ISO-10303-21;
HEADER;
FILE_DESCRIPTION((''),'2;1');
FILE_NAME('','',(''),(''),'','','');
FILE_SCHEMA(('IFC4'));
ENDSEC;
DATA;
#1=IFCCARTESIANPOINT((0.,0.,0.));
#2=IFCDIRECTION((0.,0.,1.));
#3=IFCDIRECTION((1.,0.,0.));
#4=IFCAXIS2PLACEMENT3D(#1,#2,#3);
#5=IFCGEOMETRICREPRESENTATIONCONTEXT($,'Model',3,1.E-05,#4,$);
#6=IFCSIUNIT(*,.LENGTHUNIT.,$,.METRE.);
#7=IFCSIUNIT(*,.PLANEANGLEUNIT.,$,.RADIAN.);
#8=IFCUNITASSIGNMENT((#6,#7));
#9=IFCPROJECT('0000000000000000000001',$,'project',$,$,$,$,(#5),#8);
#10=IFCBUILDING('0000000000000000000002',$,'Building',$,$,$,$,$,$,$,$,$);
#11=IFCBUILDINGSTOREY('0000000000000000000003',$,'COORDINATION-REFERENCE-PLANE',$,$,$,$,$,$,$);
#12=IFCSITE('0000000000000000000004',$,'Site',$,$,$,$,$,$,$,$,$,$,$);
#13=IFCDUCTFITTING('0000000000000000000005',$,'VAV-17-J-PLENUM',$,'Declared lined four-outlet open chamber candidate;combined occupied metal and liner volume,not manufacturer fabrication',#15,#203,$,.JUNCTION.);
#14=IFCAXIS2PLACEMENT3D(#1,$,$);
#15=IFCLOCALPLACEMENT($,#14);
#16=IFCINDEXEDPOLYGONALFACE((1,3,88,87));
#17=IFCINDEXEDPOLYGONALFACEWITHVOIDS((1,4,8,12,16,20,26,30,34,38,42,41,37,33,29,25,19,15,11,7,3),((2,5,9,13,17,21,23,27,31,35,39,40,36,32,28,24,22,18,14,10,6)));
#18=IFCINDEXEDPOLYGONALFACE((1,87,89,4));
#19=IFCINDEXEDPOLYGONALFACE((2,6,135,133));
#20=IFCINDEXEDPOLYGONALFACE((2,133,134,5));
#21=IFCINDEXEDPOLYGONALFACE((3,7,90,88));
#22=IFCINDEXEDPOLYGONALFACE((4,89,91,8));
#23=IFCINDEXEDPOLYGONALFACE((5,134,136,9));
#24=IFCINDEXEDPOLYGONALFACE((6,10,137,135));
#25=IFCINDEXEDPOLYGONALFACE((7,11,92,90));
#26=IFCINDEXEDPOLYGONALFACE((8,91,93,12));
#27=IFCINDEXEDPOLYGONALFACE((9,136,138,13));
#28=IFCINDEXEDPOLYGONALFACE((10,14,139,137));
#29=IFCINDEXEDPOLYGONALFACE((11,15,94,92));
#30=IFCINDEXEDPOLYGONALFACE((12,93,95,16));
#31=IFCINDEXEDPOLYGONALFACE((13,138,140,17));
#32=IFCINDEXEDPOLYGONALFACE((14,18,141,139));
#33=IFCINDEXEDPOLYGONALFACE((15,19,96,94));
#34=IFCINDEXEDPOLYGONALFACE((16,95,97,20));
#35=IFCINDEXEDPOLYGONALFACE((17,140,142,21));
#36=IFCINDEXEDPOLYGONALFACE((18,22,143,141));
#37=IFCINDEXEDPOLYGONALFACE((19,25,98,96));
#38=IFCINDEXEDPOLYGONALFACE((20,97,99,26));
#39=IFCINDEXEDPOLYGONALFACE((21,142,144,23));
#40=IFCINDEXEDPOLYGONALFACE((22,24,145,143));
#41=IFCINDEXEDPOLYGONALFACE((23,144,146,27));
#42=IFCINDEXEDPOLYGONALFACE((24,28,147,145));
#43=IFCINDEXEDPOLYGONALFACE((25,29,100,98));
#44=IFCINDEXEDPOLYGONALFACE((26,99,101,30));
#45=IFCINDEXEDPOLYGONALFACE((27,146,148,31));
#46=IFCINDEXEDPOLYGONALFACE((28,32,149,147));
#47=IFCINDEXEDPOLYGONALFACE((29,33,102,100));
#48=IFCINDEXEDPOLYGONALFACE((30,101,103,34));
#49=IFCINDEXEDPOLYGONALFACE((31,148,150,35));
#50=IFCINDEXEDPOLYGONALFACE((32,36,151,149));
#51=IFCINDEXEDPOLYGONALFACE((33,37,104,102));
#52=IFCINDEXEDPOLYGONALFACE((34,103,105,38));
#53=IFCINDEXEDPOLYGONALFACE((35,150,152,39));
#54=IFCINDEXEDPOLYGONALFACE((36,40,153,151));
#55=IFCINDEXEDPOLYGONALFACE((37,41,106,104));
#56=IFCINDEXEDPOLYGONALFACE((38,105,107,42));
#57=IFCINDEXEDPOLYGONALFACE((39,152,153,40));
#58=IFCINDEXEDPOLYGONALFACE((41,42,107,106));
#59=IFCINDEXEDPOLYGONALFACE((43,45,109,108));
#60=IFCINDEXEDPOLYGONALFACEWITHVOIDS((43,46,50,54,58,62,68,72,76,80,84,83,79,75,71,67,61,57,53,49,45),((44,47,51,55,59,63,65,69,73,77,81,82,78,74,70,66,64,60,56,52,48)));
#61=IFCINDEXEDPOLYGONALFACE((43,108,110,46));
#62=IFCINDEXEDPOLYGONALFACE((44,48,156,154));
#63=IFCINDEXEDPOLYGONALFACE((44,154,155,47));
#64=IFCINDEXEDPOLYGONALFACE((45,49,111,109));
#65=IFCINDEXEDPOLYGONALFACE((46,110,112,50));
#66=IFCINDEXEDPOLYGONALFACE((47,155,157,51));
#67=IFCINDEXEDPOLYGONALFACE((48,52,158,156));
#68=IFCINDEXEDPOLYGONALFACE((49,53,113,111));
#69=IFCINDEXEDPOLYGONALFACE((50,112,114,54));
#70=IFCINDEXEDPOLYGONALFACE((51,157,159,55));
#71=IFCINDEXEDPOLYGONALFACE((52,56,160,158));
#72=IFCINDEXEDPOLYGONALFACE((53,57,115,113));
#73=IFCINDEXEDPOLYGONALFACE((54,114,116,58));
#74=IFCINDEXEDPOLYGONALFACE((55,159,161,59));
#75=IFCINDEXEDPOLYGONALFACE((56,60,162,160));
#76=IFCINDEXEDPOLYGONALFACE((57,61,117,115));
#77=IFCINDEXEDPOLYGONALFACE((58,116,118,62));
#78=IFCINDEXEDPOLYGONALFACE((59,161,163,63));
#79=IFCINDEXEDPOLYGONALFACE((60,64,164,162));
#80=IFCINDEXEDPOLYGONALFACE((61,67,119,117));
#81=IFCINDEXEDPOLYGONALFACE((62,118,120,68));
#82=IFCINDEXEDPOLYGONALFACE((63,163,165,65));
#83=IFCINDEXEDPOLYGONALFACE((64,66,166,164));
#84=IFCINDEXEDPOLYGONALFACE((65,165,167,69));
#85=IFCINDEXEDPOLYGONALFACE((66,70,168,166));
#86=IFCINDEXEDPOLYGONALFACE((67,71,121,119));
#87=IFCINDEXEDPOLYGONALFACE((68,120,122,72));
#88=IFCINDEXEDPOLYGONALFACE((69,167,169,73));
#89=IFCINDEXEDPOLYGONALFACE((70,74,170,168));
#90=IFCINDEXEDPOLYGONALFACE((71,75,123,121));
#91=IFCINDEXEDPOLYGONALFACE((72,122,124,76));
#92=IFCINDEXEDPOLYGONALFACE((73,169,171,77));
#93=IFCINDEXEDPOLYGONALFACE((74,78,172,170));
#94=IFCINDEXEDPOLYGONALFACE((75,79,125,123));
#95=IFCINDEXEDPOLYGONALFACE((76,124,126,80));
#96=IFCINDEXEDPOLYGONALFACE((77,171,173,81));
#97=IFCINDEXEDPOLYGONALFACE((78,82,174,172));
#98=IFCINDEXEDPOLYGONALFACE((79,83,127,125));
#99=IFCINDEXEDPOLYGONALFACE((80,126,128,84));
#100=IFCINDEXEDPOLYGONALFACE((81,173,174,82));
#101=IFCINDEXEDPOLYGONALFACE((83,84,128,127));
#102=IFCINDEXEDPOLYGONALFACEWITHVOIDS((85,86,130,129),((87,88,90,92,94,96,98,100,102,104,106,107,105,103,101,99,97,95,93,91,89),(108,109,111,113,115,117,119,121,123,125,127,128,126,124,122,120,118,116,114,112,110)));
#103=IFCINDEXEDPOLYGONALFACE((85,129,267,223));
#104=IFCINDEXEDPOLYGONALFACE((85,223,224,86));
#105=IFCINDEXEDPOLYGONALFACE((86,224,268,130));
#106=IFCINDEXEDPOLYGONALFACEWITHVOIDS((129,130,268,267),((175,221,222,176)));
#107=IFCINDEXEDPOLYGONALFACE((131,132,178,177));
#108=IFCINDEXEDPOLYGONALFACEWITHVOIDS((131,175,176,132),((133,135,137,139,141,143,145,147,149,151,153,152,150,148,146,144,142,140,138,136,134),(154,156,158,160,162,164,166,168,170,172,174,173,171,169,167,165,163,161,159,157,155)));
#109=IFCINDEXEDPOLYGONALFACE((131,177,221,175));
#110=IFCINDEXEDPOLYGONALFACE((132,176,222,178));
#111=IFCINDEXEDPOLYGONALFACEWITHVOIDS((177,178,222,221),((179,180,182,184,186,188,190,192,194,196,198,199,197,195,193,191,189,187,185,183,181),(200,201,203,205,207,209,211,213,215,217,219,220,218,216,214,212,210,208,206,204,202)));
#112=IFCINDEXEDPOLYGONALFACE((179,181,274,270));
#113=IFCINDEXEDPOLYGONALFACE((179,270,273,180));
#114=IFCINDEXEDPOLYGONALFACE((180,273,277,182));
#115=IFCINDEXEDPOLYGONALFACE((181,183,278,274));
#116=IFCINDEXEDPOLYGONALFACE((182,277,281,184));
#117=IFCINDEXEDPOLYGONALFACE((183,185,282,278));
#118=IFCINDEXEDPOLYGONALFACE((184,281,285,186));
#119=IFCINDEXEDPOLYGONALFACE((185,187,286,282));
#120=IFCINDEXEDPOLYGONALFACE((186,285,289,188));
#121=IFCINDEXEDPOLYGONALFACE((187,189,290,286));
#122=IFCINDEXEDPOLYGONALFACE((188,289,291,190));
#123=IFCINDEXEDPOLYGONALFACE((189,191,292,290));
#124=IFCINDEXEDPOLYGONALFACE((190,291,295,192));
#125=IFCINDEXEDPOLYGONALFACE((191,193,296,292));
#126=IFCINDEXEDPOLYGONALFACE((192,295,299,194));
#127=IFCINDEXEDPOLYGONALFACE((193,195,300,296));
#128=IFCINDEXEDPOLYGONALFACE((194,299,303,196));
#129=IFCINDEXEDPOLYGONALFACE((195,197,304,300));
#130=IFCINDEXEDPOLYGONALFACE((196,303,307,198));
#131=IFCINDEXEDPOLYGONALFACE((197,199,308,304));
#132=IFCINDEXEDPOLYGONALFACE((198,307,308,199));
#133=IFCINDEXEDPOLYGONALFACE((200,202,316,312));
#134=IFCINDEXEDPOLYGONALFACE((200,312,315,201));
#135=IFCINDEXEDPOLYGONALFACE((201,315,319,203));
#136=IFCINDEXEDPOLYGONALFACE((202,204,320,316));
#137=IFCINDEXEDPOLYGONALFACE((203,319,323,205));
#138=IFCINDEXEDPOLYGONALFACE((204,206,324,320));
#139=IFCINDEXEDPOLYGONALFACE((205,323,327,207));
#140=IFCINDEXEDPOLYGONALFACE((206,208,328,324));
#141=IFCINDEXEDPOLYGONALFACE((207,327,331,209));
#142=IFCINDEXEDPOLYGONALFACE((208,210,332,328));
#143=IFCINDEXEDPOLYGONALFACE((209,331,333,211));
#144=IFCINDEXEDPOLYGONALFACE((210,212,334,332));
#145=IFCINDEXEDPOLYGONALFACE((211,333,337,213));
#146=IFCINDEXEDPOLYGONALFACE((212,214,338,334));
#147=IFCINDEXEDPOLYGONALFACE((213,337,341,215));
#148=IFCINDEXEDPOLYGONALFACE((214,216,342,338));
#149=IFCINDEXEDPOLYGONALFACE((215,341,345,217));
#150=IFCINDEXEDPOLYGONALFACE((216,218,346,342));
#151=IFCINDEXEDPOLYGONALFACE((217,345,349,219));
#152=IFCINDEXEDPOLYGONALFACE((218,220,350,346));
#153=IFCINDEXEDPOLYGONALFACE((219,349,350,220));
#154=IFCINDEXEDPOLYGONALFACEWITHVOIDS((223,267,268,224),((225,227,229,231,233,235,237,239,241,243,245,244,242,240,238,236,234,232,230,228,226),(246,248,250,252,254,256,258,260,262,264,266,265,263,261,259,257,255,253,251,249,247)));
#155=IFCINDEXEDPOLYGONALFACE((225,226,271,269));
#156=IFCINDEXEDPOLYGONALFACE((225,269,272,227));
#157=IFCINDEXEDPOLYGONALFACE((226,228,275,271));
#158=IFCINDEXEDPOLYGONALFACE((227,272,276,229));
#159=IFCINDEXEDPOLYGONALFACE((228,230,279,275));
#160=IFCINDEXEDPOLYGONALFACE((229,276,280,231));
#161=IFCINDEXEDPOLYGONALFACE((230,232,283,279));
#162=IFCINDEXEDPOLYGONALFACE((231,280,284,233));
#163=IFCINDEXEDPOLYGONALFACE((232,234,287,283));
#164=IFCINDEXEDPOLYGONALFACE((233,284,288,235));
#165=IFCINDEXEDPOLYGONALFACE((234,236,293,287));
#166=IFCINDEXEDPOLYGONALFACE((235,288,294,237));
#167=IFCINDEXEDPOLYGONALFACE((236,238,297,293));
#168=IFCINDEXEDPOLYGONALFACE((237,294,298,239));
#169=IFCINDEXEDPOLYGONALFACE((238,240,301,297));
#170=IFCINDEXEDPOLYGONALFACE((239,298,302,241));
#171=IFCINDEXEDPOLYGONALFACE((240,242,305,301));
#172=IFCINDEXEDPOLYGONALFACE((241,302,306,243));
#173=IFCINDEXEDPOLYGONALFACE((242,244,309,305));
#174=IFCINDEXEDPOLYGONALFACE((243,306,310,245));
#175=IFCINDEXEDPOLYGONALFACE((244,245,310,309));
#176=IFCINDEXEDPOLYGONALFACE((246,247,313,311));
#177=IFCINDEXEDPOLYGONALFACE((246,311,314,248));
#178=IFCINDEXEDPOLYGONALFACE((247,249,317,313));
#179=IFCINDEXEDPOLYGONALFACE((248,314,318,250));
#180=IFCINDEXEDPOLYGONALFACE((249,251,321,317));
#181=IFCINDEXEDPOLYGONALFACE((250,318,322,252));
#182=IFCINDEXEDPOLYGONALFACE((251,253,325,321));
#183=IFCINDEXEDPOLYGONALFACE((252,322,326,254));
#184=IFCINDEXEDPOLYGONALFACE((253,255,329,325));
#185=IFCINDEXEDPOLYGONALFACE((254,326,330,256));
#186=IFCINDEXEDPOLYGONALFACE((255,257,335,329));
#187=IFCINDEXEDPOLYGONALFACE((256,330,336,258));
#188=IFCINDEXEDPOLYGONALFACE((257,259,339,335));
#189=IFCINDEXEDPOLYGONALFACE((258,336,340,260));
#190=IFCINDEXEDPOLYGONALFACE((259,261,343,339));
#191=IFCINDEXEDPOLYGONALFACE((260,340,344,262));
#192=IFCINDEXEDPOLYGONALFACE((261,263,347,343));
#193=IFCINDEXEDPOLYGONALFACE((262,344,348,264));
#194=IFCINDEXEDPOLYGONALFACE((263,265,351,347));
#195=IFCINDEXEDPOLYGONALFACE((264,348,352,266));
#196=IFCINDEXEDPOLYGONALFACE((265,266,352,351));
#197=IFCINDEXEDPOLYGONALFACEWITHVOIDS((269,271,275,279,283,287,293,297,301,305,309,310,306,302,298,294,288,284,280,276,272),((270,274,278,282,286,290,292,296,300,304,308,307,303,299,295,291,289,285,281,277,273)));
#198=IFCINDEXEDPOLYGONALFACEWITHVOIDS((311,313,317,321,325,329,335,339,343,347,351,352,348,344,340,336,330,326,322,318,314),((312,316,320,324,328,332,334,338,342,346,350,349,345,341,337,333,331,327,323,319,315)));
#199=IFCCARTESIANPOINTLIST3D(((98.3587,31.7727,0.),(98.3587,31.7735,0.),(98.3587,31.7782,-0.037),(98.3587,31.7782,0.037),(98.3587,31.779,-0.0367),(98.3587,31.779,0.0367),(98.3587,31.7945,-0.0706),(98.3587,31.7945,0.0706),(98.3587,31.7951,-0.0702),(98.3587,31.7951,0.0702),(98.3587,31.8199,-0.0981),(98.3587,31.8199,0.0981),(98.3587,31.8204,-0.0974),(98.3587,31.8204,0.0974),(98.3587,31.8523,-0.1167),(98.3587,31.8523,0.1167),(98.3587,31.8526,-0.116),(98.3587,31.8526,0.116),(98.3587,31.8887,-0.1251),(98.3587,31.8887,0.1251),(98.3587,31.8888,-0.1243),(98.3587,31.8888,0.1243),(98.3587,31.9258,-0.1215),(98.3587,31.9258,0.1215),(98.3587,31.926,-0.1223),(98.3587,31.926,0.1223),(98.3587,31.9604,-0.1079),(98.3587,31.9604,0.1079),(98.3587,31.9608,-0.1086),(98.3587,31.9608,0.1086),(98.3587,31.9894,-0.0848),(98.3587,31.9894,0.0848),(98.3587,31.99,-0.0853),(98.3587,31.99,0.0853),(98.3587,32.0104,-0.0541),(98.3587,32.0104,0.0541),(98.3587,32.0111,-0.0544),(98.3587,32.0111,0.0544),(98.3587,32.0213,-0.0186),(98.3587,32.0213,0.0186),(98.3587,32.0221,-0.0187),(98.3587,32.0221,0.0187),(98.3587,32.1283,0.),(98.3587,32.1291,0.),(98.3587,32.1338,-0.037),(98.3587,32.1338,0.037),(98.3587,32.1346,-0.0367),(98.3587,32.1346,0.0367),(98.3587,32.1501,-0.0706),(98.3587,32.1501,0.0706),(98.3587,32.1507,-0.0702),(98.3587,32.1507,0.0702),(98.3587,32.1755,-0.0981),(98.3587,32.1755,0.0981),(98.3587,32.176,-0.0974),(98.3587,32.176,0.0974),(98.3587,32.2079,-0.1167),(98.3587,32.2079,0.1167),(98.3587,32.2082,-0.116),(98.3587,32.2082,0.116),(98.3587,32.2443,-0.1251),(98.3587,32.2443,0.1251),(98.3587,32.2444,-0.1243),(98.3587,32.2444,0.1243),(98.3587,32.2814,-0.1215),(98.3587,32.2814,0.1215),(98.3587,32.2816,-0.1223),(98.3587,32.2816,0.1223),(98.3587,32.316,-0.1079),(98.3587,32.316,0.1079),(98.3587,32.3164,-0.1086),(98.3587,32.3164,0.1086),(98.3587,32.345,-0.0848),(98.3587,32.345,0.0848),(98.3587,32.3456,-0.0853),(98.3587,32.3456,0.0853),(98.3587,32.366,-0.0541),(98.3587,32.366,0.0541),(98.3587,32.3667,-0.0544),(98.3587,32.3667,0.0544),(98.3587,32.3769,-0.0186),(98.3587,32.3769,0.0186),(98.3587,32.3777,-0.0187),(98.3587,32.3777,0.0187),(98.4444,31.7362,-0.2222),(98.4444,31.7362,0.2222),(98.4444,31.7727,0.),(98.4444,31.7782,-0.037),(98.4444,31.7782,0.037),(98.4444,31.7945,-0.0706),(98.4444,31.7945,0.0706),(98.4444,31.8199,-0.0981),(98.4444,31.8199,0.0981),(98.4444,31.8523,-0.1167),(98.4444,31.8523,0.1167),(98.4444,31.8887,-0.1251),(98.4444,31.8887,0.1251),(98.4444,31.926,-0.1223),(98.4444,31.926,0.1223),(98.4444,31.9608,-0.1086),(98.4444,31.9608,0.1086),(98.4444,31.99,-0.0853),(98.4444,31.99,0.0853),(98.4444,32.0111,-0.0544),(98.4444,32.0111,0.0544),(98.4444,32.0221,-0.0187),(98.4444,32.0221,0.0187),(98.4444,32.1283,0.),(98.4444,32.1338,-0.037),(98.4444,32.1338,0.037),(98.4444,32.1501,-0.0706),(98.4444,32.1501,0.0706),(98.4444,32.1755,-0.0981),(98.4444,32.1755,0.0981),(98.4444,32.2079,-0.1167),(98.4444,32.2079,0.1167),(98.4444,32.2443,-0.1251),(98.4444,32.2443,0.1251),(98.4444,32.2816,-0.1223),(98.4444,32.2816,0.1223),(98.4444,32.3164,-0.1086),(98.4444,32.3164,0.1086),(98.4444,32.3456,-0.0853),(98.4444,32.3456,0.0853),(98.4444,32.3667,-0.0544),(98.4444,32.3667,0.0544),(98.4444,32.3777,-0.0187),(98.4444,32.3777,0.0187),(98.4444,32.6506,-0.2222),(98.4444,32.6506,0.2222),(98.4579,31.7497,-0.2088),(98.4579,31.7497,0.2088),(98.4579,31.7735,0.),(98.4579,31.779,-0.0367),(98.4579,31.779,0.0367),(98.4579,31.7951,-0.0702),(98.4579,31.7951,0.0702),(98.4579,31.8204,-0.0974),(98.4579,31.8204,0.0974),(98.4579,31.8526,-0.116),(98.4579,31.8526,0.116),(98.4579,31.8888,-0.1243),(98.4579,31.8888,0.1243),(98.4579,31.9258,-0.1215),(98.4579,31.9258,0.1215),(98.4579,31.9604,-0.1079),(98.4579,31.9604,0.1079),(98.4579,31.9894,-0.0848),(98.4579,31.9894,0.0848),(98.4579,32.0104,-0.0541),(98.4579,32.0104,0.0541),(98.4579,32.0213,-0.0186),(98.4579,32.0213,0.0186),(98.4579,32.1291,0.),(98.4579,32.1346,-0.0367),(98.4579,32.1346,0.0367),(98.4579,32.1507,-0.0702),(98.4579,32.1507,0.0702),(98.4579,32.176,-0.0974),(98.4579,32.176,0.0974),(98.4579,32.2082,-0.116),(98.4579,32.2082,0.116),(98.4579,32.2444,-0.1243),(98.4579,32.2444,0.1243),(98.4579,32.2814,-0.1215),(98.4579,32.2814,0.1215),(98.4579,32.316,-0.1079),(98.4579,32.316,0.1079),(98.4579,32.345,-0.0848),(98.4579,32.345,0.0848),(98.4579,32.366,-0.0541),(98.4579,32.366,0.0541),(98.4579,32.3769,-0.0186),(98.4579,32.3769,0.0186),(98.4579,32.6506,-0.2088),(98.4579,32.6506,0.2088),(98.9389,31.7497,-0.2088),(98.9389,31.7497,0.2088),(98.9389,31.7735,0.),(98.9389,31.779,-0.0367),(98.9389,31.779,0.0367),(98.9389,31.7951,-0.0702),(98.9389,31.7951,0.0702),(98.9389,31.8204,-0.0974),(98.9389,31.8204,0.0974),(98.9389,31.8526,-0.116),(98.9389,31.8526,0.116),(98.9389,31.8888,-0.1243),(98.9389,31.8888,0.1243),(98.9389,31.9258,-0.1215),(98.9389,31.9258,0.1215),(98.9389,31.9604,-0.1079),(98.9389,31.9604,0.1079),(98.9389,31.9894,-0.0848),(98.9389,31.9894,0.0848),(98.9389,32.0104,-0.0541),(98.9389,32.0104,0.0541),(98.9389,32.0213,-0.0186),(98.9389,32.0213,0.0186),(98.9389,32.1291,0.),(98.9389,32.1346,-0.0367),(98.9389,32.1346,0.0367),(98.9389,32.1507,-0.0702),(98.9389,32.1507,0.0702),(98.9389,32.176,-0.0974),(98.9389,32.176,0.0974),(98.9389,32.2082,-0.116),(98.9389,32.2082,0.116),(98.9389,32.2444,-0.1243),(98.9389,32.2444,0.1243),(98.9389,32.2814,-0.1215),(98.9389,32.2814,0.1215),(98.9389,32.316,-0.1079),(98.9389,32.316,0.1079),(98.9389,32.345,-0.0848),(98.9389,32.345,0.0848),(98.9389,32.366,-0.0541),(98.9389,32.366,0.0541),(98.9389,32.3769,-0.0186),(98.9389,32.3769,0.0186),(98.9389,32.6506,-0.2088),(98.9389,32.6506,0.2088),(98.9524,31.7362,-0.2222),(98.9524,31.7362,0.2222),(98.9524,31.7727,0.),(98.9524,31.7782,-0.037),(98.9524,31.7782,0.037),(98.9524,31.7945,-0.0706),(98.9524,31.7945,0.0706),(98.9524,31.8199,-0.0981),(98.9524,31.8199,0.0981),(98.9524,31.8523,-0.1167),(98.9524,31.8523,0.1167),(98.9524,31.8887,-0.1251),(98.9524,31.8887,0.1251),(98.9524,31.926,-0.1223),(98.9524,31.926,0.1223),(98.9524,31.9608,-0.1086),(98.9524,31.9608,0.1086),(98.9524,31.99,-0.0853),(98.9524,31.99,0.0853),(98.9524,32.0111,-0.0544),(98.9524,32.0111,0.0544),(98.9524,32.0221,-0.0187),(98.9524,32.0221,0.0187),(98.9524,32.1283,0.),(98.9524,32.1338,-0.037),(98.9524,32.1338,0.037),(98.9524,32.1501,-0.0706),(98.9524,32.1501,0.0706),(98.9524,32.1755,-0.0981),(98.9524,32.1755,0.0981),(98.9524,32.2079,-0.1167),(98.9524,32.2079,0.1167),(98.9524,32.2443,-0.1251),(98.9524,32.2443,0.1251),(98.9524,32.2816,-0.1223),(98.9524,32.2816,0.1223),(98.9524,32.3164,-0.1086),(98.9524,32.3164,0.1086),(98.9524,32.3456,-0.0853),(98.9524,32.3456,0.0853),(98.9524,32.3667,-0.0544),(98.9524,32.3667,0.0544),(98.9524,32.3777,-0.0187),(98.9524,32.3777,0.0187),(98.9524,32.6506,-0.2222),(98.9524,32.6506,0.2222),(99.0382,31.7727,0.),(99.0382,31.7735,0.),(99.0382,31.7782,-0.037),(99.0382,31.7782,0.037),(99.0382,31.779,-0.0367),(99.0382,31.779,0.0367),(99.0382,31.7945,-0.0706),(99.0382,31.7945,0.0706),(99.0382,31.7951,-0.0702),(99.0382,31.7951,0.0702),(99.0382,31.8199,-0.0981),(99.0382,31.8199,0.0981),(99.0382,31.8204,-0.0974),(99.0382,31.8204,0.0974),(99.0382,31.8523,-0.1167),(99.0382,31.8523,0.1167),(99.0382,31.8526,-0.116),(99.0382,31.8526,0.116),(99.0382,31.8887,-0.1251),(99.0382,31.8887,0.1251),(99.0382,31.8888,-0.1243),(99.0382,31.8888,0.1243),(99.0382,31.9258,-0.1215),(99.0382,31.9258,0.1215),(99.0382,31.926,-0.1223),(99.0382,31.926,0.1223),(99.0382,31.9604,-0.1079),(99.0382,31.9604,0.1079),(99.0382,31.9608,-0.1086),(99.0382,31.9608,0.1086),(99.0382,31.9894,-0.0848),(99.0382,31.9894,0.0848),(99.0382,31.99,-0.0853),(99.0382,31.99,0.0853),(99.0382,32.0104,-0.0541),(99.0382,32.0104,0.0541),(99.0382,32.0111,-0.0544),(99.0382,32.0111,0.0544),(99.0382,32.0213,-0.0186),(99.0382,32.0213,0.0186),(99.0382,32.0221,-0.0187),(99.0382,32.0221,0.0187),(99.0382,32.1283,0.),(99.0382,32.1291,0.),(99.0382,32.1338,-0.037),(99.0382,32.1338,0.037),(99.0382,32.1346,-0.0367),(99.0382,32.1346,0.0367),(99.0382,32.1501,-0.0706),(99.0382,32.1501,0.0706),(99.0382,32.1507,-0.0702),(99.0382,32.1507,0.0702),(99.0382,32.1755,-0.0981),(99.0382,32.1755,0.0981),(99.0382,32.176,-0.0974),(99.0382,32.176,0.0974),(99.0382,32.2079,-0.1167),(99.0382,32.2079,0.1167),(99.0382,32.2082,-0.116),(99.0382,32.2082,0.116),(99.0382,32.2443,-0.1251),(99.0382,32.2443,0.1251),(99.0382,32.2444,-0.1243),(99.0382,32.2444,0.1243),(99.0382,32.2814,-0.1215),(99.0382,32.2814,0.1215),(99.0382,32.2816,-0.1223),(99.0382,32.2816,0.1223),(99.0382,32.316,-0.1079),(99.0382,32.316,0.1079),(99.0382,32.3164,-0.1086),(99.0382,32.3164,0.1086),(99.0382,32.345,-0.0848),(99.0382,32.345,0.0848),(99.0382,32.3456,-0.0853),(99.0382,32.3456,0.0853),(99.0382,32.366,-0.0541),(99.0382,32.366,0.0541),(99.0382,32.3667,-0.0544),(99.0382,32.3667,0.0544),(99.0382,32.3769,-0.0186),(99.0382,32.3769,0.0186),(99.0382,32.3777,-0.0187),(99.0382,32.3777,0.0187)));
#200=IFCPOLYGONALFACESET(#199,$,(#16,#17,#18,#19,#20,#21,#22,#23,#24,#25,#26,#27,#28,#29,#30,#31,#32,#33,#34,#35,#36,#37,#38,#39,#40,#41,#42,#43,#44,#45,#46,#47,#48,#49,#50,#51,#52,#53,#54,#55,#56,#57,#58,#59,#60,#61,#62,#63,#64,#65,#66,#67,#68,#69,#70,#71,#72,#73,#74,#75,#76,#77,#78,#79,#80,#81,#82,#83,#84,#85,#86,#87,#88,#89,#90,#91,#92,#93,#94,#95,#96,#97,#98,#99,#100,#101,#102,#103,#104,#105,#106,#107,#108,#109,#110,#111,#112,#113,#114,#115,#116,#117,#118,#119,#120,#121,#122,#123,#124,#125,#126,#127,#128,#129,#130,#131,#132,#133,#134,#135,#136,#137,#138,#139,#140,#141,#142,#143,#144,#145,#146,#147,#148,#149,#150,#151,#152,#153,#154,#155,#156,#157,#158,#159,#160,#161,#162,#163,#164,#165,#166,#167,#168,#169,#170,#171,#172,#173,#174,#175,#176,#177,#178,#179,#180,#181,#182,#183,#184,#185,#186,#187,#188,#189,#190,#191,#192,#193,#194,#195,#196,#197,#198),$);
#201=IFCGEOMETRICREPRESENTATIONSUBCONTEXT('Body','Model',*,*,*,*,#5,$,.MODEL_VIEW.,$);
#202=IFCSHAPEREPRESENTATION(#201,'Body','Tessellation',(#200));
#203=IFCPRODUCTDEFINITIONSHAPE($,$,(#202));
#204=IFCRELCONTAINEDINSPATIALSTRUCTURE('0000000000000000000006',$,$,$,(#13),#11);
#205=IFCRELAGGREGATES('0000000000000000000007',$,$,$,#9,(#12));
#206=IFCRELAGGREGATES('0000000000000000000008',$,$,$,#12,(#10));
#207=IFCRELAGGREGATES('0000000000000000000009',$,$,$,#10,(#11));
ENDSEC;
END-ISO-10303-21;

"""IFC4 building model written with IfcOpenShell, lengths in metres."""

from ifc_helpers import new_model, si_unit, frame, origin_with_axes, place, context, subcontext, project, spatial, rectangle, circle, extrude, boolean, element, save


model = new_model("IFC4")

# Units and contexts
model_context = context("Model", 3, precision=1e-05, world=origin_with_axes())
body_context_1 = subcontext(model_context, "Body", "Model", "MODEL_VIEW")
ifc_project = project(units=[si_unit("LENGTHUNIT", "METRE"), si_unit("PLANEANGLEUNIT", "RADIAN")], contexts=[model_context])

# Site, building, storey
site = spatial("IfcSite", under=ifc_project, Name="Site")
building = spatial("IfcBuilding", under=site, Name="Building")
storey = spatial("IfcBuildingStorey", under=building, Name="COORDINATION-REFERENCE-PLANE")

# Duct fitting
duct_fitting_1_placement = place(None, frame((98.4444, 31.7362, -0.2223), z_axis=(0.0, 0.0, 1.0), x_axis=(1.0, 0.0, 0.0)))
solid_1 = boolean("UNION", boolean("UNION", boolean("UNION", boolean("UNION", extrude(rectangle(XDim=0.481, YDim=0.4175), frame((0.254, 0.9244, 0.2223), z_axis=(0.0, -1.0, 0.0), x_axis=(1.0, 0.0, 0.0)), (0.0, 0.0, 1.0), 0.9109), extrude(circle(Radius=0.1246), frame((0.0235, 0.5175, 0.2223), z_axis=(-1.0, 0.0, 0.0), x_axis=(0.0, -1.0, 0.0)), (0.0, 0.0, 1.0), 0.1192)), extrude(circle(Radius=0.1246), frame((0.4845, 0.5175, 0.2223), z_axis=(1.0, 0.0, 0.0), x_axis=(0.0, -1.0, 0.0)), (0.0, 0.0, 1.0), 0.1192)), extrude(circle(Radius=0.1246), frame((0.0235, 0.1619, 0.2223), z_axis=(-1.0, 0.0, 0.0), x_axis=(0.0, -1.0, 0.0)), (0.0, 0.0, 1.0), 0.1192)), extrude(circle(Radius=0.1246), frame((0.4845, 0.1619, 0.2223), z_axis=(1.0, 0.0, 0.0), x_axis=(0.0, -1.0, 0.0)), (0.0, 0.0, 1.0), 0.1192))
element("IfcDuctFitting", 1, at=duct_fitting_1_placement, inside=storey, Name="VAV-17-J-PLENUM", ObjectType="Declared lined four-outlet open chamber candidate;combined occupied metal and liner volume,not manufacturer fabrication", PredefinedType="JUNCTION", context=body_context_1, shape_type="CSG", body=[
    boolean("DIFFERENCE", boolean("UNION", boolean("UNION", boolean("UNION", boolean("UNION", extrude(rectangle(XDim=0.508, YDim=0.4445), frame((0.254, 0.9144, 0.2223), z_axis=(0.0, -1.0, 0.0), x_axis=(1.0, 0.0, 0.0)), (0.0, 0.0, 1.0), 0.9144), extrude(circle(Radius=0.1254), frame((0.0235, 0.5175, 0.2223), z_axis=(-1.0, 0.0, 0.0), x_axis=(0.0, -1.0, 0.0)), (0.0, 0.0, 1.0), 0.1092)), extrude(circle(Radius=0.1254), frame((0.4845, 0.5175, 0.2223), z_axis=(1.0, 0.0, 0.0), x_axis=(0.0, -1.0, 0.0)), (0.0, 0.0, 1.0), 0.1092)), extrude(circle(Radius=0.1254), frame((0.0235, 0.1619, 0.2223), z_axis=(-1.0, 0.0, 0.0), x_axis=(0.0, -1.0, 0.0)), (0.0, 0.0, 1.0), 0.1092)), extrude(circle(Radius=0.1254), frame((0.4845, 0.1619, 0.2223), z_axis=(1.0, 0.0, 0.0), x_axis=(0.0, -1.0, 0.0)), (0.0, 0.0, 1.0), 0.1092)), solid_1),
])

save(model, "model.ifc")
